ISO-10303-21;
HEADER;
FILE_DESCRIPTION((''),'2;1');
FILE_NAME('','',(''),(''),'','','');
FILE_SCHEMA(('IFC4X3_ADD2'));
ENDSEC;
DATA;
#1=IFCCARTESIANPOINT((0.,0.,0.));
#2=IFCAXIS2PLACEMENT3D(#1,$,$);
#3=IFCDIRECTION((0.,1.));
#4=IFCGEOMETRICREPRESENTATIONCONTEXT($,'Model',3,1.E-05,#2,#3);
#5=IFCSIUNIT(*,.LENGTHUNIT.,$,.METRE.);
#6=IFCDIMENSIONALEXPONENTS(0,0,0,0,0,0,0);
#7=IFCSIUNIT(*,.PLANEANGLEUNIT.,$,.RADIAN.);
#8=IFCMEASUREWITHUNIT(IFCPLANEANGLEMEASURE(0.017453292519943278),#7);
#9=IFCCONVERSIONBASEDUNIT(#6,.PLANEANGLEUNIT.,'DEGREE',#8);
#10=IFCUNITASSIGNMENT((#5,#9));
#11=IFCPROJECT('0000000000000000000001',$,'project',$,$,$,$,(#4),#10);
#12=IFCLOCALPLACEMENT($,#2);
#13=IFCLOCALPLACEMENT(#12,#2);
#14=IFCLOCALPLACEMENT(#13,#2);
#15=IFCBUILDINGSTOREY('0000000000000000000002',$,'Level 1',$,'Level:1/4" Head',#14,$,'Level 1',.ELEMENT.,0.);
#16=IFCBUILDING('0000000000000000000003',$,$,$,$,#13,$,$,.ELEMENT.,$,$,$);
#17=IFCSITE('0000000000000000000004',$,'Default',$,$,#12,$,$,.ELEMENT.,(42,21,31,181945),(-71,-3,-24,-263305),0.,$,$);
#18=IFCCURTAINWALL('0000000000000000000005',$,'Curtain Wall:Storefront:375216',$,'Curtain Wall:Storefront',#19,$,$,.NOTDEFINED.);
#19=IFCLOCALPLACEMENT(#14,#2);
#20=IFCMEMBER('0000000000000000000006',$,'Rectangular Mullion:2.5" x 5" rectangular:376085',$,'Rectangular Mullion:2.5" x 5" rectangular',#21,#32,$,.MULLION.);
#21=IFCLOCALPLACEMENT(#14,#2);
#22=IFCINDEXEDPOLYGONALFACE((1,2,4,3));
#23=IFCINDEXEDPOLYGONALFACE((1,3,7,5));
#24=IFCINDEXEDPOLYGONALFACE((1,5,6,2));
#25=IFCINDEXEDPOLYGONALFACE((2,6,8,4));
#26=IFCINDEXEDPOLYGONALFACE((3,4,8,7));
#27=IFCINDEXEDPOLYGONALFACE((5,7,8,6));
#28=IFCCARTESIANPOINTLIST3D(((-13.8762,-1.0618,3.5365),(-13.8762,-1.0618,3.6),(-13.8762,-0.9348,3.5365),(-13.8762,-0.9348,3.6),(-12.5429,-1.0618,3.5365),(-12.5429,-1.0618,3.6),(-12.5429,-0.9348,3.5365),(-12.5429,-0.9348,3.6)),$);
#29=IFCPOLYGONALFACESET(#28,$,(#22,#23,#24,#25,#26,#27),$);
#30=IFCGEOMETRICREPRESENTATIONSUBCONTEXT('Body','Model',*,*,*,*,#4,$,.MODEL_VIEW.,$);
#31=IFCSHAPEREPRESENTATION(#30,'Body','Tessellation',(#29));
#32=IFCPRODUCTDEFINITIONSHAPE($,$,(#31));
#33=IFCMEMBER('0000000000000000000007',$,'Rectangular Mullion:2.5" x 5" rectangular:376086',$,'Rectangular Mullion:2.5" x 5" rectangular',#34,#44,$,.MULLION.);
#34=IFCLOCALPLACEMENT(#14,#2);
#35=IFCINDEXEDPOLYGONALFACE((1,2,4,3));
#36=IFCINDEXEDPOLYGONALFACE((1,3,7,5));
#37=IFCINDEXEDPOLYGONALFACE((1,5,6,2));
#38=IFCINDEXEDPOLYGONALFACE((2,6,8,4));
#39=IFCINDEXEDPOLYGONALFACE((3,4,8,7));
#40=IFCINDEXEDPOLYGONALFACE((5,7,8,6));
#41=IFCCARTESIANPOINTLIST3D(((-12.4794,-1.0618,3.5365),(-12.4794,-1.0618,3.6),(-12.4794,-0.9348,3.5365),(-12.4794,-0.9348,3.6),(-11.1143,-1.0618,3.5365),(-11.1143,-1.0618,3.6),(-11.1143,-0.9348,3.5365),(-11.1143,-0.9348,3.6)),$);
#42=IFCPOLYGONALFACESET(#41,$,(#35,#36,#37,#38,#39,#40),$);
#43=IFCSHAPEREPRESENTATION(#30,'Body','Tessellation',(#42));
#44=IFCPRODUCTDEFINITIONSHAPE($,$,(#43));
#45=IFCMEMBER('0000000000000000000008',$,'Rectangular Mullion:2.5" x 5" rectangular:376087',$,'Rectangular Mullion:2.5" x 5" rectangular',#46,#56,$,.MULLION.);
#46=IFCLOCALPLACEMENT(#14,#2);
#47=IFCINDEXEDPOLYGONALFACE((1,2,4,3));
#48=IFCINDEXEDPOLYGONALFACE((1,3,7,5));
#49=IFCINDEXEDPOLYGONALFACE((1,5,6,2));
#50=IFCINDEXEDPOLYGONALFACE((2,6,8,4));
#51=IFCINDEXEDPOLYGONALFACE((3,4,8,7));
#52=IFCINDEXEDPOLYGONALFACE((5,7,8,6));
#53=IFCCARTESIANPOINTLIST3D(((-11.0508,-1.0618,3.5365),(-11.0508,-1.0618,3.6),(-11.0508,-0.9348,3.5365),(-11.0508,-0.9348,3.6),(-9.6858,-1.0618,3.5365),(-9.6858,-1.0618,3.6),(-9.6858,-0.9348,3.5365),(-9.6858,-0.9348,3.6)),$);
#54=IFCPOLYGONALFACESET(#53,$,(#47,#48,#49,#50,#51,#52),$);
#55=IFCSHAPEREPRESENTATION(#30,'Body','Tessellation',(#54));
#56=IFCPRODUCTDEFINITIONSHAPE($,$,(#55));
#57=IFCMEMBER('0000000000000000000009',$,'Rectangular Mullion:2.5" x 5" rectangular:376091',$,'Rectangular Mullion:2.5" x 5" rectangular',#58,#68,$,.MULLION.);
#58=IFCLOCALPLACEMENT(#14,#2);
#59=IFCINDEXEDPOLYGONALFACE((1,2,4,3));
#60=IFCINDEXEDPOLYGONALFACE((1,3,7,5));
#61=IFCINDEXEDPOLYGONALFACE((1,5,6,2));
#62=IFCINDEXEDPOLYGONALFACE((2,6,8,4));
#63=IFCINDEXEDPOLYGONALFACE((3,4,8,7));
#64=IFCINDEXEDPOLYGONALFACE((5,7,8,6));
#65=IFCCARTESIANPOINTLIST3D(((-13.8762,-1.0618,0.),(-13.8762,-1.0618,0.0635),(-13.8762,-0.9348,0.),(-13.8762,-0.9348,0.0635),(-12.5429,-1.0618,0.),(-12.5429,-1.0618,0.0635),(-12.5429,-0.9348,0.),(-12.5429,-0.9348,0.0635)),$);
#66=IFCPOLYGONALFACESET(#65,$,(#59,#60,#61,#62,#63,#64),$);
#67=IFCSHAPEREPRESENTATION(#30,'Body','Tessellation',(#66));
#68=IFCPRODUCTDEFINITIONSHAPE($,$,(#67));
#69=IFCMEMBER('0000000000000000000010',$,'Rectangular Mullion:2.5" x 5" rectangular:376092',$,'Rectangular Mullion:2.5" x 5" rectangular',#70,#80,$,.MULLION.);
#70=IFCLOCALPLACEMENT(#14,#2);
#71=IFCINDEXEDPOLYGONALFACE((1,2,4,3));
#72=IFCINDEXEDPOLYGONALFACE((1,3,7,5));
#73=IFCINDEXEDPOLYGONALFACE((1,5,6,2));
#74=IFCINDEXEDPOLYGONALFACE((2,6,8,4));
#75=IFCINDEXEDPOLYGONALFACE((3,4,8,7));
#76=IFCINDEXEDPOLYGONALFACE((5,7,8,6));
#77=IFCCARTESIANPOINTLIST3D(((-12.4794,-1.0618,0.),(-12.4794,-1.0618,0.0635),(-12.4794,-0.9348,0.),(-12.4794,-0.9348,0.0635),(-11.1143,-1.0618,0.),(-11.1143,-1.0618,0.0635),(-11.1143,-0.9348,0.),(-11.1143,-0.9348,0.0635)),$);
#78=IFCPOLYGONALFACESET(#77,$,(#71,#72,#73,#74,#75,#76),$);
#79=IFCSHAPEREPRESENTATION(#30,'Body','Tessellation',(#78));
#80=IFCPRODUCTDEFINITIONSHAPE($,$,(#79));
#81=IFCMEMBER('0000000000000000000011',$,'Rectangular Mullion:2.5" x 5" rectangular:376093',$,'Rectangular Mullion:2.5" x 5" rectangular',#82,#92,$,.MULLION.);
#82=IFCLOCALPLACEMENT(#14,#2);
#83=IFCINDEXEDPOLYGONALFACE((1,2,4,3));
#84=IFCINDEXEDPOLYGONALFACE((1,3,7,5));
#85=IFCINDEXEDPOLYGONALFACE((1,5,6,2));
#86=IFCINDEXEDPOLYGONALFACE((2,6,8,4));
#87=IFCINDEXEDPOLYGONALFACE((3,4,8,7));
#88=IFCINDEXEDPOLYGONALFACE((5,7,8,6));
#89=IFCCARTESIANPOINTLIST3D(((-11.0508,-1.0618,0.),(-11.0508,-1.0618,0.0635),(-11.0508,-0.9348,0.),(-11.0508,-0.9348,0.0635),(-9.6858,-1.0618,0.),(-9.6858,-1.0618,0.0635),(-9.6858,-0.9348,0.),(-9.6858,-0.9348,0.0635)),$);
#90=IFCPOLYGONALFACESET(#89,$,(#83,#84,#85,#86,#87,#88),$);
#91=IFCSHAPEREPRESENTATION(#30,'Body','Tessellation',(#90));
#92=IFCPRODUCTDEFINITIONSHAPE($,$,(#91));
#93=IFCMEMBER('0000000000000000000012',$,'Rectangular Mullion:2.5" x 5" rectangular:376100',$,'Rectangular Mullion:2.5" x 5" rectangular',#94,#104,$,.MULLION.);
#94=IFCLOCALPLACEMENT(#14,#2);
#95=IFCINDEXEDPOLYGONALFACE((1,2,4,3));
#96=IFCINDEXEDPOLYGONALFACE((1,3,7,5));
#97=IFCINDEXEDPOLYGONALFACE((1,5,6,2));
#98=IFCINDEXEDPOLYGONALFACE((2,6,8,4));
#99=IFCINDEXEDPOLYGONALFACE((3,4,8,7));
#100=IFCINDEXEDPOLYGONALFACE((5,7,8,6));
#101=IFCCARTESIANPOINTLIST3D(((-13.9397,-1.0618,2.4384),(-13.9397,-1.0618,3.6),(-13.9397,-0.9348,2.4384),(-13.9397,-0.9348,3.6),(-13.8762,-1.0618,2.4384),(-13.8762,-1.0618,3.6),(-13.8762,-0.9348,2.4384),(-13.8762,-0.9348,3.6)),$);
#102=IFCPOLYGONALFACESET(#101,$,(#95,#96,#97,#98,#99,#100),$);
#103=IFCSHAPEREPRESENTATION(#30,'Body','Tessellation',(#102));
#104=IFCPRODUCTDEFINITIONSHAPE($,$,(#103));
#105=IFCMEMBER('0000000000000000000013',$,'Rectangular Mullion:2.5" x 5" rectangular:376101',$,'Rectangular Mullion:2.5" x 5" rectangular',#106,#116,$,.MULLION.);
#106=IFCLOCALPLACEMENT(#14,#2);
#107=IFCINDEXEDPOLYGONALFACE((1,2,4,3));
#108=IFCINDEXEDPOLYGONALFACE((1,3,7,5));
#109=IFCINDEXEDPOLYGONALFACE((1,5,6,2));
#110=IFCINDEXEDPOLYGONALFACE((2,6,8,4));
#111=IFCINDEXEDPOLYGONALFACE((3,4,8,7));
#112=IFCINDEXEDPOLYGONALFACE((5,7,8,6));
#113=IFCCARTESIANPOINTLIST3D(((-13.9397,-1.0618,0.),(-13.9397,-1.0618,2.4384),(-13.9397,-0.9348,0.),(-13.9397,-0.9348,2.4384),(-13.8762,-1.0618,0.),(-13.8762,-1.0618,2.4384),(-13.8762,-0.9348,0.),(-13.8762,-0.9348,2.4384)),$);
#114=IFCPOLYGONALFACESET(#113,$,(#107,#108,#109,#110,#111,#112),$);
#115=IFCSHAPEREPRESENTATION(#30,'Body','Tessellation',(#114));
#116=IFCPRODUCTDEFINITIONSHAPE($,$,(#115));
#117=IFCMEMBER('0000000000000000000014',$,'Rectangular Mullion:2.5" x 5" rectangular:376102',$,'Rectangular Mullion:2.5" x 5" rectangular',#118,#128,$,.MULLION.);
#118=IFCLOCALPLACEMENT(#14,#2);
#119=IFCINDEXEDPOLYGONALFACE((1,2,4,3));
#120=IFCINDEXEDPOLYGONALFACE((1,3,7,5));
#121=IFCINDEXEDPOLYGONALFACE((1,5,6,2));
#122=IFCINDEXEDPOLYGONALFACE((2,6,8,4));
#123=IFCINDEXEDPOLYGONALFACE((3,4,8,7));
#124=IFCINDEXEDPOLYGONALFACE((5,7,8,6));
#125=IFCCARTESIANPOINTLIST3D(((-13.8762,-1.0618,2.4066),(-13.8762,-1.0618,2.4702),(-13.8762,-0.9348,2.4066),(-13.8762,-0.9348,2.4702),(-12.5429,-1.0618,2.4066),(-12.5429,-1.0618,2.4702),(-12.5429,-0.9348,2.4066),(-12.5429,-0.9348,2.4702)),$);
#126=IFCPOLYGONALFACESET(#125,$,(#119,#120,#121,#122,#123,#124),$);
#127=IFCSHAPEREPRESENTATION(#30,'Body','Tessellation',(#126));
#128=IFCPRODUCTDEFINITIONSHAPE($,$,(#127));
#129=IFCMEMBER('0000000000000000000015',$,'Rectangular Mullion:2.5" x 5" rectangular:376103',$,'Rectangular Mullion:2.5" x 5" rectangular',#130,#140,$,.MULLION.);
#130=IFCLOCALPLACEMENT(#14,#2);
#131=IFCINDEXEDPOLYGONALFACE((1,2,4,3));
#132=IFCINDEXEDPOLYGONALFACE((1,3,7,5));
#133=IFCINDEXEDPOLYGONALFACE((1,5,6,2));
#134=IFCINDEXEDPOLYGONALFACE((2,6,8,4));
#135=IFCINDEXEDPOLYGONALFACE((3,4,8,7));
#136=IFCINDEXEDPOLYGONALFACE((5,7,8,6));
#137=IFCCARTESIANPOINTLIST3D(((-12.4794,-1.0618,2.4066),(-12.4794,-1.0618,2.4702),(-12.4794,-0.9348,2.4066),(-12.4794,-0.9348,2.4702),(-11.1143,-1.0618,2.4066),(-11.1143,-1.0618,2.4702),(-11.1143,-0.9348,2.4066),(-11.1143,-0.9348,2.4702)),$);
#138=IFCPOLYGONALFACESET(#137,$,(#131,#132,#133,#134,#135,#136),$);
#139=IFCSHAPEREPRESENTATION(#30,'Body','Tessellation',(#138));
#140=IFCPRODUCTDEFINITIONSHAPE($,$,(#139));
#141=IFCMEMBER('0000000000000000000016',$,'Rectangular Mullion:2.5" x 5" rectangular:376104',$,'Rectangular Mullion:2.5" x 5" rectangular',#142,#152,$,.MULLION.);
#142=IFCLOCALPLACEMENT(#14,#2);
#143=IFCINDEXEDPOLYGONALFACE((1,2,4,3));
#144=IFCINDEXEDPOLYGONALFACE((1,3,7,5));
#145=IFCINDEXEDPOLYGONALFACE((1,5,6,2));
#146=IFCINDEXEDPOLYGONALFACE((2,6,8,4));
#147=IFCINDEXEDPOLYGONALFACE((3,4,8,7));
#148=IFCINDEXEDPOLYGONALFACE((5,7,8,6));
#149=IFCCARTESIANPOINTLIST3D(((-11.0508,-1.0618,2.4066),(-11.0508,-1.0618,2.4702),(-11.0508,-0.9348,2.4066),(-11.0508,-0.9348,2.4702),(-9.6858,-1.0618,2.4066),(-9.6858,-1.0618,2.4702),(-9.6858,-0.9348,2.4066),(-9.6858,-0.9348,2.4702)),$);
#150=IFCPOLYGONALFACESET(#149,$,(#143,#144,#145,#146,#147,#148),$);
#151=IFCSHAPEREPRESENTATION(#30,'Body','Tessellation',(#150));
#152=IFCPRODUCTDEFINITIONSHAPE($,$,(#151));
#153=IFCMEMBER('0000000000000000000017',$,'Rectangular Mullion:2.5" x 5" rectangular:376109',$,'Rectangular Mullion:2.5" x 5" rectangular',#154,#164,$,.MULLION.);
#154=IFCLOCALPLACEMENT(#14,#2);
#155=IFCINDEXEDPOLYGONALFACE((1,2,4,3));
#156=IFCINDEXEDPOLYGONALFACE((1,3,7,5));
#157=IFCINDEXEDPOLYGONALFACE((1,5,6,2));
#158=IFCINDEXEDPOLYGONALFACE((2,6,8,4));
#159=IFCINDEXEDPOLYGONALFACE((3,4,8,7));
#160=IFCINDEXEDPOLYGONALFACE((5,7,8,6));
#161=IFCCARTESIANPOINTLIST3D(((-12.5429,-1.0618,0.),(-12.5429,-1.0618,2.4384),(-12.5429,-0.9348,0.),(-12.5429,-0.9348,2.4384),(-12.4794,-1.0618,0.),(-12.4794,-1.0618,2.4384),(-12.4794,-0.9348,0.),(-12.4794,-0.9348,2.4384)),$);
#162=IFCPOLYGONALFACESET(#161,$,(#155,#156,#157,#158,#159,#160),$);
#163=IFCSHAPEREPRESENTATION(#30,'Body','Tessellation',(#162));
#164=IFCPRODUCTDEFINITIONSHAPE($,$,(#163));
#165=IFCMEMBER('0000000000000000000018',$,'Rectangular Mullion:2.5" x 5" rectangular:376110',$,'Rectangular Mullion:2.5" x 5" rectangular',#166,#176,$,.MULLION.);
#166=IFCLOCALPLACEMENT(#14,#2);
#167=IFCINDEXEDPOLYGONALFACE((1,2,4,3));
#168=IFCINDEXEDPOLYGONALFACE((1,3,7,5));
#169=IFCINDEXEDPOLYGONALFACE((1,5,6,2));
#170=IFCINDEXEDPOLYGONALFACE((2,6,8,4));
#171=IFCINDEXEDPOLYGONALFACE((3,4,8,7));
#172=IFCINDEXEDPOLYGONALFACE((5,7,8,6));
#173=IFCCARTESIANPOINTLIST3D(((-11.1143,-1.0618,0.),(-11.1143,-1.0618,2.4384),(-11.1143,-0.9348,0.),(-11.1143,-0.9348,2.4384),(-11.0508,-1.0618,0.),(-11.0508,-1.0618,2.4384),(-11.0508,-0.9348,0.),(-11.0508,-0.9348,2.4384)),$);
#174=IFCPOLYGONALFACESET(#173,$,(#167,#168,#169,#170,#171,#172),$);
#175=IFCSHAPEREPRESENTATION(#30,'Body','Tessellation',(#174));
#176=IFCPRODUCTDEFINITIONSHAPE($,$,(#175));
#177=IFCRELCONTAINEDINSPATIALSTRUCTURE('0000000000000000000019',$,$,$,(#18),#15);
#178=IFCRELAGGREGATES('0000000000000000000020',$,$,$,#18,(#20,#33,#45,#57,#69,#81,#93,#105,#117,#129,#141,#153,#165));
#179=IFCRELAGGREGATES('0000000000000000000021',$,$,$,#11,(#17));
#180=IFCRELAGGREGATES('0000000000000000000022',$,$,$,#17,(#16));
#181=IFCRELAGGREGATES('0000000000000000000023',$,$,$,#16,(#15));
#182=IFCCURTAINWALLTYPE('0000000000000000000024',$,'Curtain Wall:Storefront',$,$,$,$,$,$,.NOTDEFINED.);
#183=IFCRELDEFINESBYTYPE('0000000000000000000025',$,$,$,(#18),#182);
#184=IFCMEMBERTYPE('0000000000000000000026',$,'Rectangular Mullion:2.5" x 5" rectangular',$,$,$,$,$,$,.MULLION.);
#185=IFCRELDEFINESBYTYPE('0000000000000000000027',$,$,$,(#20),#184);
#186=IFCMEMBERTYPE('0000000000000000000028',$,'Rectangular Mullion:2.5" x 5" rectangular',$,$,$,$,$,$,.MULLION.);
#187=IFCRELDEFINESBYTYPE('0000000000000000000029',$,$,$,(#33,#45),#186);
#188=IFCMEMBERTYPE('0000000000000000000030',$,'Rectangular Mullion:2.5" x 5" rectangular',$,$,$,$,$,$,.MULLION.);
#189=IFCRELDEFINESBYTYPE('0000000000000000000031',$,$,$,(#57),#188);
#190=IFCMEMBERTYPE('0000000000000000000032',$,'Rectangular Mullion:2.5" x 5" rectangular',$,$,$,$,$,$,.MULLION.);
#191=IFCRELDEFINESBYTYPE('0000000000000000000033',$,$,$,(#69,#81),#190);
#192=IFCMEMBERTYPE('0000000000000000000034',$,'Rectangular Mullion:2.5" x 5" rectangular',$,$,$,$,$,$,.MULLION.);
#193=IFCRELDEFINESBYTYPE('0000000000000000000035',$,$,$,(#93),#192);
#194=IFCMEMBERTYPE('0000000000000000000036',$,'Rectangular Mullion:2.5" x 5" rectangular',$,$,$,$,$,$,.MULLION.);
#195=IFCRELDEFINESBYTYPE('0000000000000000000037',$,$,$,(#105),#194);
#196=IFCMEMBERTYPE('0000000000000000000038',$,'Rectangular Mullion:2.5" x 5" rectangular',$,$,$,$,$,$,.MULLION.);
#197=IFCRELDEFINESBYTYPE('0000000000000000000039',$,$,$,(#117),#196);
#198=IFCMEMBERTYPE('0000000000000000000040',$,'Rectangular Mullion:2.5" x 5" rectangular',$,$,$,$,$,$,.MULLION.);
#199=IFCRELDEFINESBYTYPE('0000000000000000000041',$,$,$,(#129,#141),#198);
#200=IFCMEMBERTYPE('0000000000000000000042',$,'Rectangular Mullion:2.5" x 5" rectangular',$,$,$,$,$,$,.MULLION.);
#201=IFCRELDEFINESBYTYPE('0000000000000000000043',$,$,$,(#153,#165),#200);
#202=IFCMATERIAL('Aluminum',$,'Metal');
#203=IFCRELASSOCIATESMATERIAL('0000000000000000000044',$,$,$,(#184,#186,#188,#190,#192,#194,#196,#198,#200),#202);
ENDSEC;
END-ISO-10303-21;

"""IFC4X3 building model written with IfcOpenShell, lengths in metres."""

from ifc_helpers import new_model, entity, si_unit, converted_unit, direction, frame, frame_2d, origin, origin_2d_with_axis, place, context, subcontext, project, spatial, rectangle, extrude, source, transform, mapped, material, material_profile, profile_set, type_object, type_shapes, element, aggregate, save


model = new_model("IFC4X3")

# Units and contexts
model_context = context("Model", 3, precision=1e-05, world=origin(), true_north=direction((0.0, 1.0)))
body_context = subcontext(model_context, "Body", "Model", "MODEL_VIEW")
ifc_project = project(units=[si_unit("LENGTHUNIT", "METRE"), converted_unit("PLANEANGLEUNIT", "DEGREE", entity("IfcPlaneAngleMeasure", 0.017453292519943278), si_unit("PLANEANGLEUNIT", "RADIAN"), dimensions=[0, 0, 0, 0, 0, 0, 0])], contexts=[model_context])

# Site, building, storey
site_placement = place(None, origin())
site = spatial("IfcSite", under=ifc_project, at=site_placement, Name="Default", CompositionType="ELEMENT", RefLatitude=(42, 21, 31, 181945), RefLongitude=(-71, -3, -24, -263305), RefElevation=0.0)
building_placement = place(site_placement, origin())
building = spatial("IfcBuilding", under=site, at=building_placement, CompositionType="ELEMENT")
storey_placement = place(building_placement, origin())
storey = spatial("IfcBuildingStorey", under=building, at=storey_placement, Name="Level 1", ObjectType="Level:1/4\" Head", LongName="Level 1", CompositionType="ELEMENT", Elevation=0.0)

# Curtain wall, members
curtain_wall_type = type_object("IfcCurtainWallType", Name="Curtain Wall:Storefront", PredefinedType="NOTDEFINED")
curtain_wall_placement = place(storey_placement, origin())
curtain_wall = element("IfcCurtainWall", 1, at=curtain_wall_placement, inside=storey, type_object=curtain_wall_type, Name="Curtain Wall:Storefront:375216", ObjectType="Curtain Wall:Storefront", PredefinedType="NOTDEFINED")
ifc_material_1 = material(Name="Aluminum", Category="Metal")
ifc_material_profile = material_profile(ifc_material_1, rectangle(XDim=0.0635, YDim=0.127, at=frame_2d((0.0, 0.0), x_axis=(1.0, 0.0))), Name="2.5\" x 5\" rectangular")
ifc_profile_set = profile_set([ifc_material_profile], Name="2.5\" x 5\" rectangular")
member_type_1 = type_object("IfcMemberType", Name="Rectangular Mullion:2.5\" x 5\" rectangular", PredefinedType="MULLION", material=ifc_profile_set)
shared_shape_1 = source(origin(), body_context, "Body", "SweptSolid", [
    extrude(rectangle(XDim=0.0635, YDim=0.127, at=frame_2d((0.0, 0.0), x_axis=(1.0, 0.0))), frame((-0.0318, 0.0, -1.3333), z_axis=(0.0, 0.0, 1.0), x_axis=(-1.0, 0.0, 0.0)), (0.0, 0.0, 1.0), 1.3333),
])
type_shapes(member_type_1, [shared_shape_1])
member_1_placement = place(curtain_wall_placement, frame((-12.5429, -0.9983, 3.6), z_axis=(1.0, 0.0, 0.0), x_axis=(0.0, 0.0, 1.0)))
member_1 = element("IfcMember", 2, at=member_1_placement, type_object=member_type_1, Name="Rectangular Mullion:2.5\" x 5\" rectangular:376085", ObjectType="Rectangular Mullion:2.5\" x 5\" rectangular", PredefinedType="MULLION", context=body_context, shape_type="MappedRepresentation", body=[
    mapped(shared_shape_1, transform((0.0, 0.0, 0.0), scale=1.0)),
])
member_type_2 = type_object("IfcMemberType", Name="Rectangular Mullion:2.5\" x 5\" rectangular", PredefinedType="MULLION", material=ifc_profile_set)
shared_shape_2 = source(origin(), body_context, "Body", "SweptSolid", [
    extrude(rectangle(XDim=0.0635, YDim=0.127, at=frame_2d((0.0, 0.0), x_axis=(1.0, 0.0))), frame((-0.0318, 0.0, -1.3651), z_axis=(0.0, 0.0, 1.0), x_axis=(-1.0, 0.0, 0.0)), (0.0, 0.0, 1.0), 1.3651),
])
type_shapes(member_type_2, [shared_shape_2])
member_2_placement = place(curtain_wall_placement, frame((-11.1143, -0.9983, 3.6), z_axis=(1.0, 0.0, 0.0), x_axis=(0.0, 0.0, 1.0)))
member_2 = element("IfcMember", 3, at=member_2_placement, type_object=member_type_2, Name="Rectangular Mullion:2.5\" x 5\" rectangular:376086", ObjectType="Rectangular Mullion:2.5\" x 5\" rectangular", PredefinedType="MULLION", context=body_context, shape_type="MappedRepresentation", body=[
    mapped(shared_shape_2, transform((0.0, 0.0, 0.0), scale=1.0)),
])
member_3_placement = place(curtain_wall_placement, frame((-9.6858, -0.9983, 3.6), z_axis=(1.0, 0.0, 0.0), x_axis=(0.0, 0.0, 1.0)))
member_3 = element("IfcMember", 4, at=member_3_placement, type_object=member_type_2, Name="Rectangular Mullion:2.5\" x 5\" rectangular:376087", ObjectType="Rectangular Mullion:2.5\" x 5\" rectangular", PredefinedType="MULLION", context=body_context, shape_type="MappedRepresentation", body=[
    mapped(shared_shape_2, transform((0.0, 0.0, 0.0), scale=1.0)),
])
member_type_3 = type_object("IfcMemberType", Name="Rectangular Mullion:2.5\" x 5\" rectangular", PredefinedType="MULLION", material=ifc_profile_set)
shared_shape_3 = source(origin(), body_context, "Body", "SweptSolid", [
    extrude(rectangle(XDim=0.0635, YDim=0.127, at=frame_2d((0.0, 0.0), x_axis=(1.0, 0.0))), frame((-0.0318, 0.0, -1.3333), z_axis=(0.0, 0.0, 1.0), x_axis=(-1.0, 0.0, 0.0)), (0.0, 0.0, 1.0), 1.3333),
])
type_shapes(member_type_3, [shared_shape_3])
member_4_placement = place(curtain_wall_placement, frame((-13.8762, -0.9983, 0.0), z_axis=(-1.0, 0.0, 0.0), x_axis=(0.0, 0.0, -1.0)))
member_4 = element("IfcMember", 5, at=member_4_placement, type_object=member_type_3, Name="Rectangular Mullion:2.5\" x 5\" rectangular:376091", ObjectType="Rectangular Mullion:2.5\" x 5\" rectangular", PredefinedType="MULLION", context=body_context, shape_type="MappedRepresentation", body=[
    mapped(shared_shape_3, transform((0.0, 0.0, 0.0), scale=1.0)),
])
member_type_4 = type_object("IfcMemberType", Name="Rectangular Mullion:2.5\" x 5\" rectangular", PredefinedType="MULLION", material=ifc_profile_set)
shared_shape_4 = source(origin(), body_context, "Body", "SweptSolid", [
    extrude(rectangle(XDim=0.0635, YDim=0.127, at=frame_2d((0.0, 0.0), x_axis=(1.0, 0.0))), frame((-0.0318, 0.0, -1.3651), z_axis=(0.0, 0.0, 1.0), x_axis=(-1.0, 0.0, 0.0)), (0.0, 0.0, 1.0), 1.3651),
])
type_shapes(member_type_4, [shared_shape_4])
member_5_placement = place(curtain_wall_placement, frame((-12.4794, -0.9983, 0.0), z_axis=(-1.0, 0.0, 0.0), x_axis=(0.0, 0.0, -1.0)))
member_5 = element("IfcMember", 6, at=member_5_placement, type_object=member_type_4, Name="Rectangular Mullion:2.5\" x 5\" rectangular:376092", ObjectType="Rectangular Mullion:2.5\" x 5\" rectangular", PredefinedType="MULLION", context=body_context, shape_type="MappedRepresentation", body=[
    mapped(shared_shape_4, transform((0.0, 0.0, 0.0), scale=1.0)),
])
member_6_placement = place(curtain_wall_placement, frame((-11.0508, -0.9983, 0.0), z_axis=(-1.0, 0.0, 0.0), x_axis=(0.0, 0.0, -1.0)))
member_6 = element("IfcMember", 7, at=member_6_placement, type_object=member_type_4, Name="Rectangular Mullion:2.5\" x 5\" rectangular:376093", ObjectType="Rectangular Mullion:2.5\" x 5\" rectangular", PredefinedType="MULLION", context=body_context, shape_type="MappedRepresentation", body=[
    mapped(shared_shape_4, transform((0.0, 0.0, 0.0), scale=1.0)),
])
member_type_5 = type_object("IfcMemberType", Name="Rectangular Mullion:2.5\" x 5\" rectangular", PredefinedType="MULLION", material=ifc_profile_set)
shared_shape_5 = source(origin(), body_context, "Body", "SweptSolid", [
    extrude(rectangle(XDim=0.0635, YDim=0.127, at=frame_2d((0.0, 0.0), x_axis=(1.0, 0.0))), frame((-0.0318, 0.0, -1.1616), z_axis=(0.0, 0.0, 1.0), x_axis=(-1.0, 0.0, 0.0)), (0.0, 0.0, 1.0), 1.1616),
])
type_shapes(member_type_5, [shared_shape_5])
member_7_placement = place(curtain_wall_placement, frame((-13.9397, -0.9983, 3.6), z_axis=(0.0, 0.0, 1.0), x_axis=(-1.0, 0.0, 0.0)))
member_7 = element("IfcMember", 8, at=member_7_placement, type_object=member_type_5, Name="Rectangular Mullion:2.5\" x 5\" rectangular:376100", ObjectType="Rectangular Mullion:2.5\" x 5\" rectangular", PredefinedType="MULLION", context=body_context, shape_type="MappedRepresentation", body=[
    mapped(shared_shape_5, transform((0.0, 0.0, 0.0), scale=1.0)),
])
member_type_6 = type_object("IfcMemberType", Name="Rectangular Mullion:2.5\" x 5\" rectangular", PredefinedType="MULLION", material=ifc_profile_set)
shared_shape_6 = source(origin(), body_context, "Body", "SweptSolid", [
    extrude(rectangle(XDim=0.0635, YDim=0.127, at=frame_2d((0.0, 0.0), x_axis=(1.0, 0.0))), frame((-0.0318, 0.0, -2.4384), z_axis=(0.0, 0.0, 1.0), x_axis=(-1.0, 0.0, 0.0)), (0.0, 0.0, 1.0), 2.4384),
])
type_shapes(member_type_6, [shared_shape_6])
member_8_placement = place(curtain_wall_placement, frame((-13.9397, -0.9983, 2.4384), z_axis=(0.0, 0.0, 1.0), x_axis=(-1.0, 0.0, 0.0)))
member_8 = element("IfcMember", 9, at=member_8_placement, type_object=member_type_6, Name="Rectangular Mullion:2.5\" x 5\" rectangular:376101", ObjectType="Rectangular Mullion:2.5\" x 5\" rectangular", PredefinedType="MULLION", context=body_context, shape_type="MappedRepresentation", body=[
    mapped(shared_shape_6, transform((0.0, 0.0, 0.0), scale=1.0)),
])
member_type_7 = type_object("IfcMemberType", Name="Rectangular Mullion:2.5\" x 5\" rectangular", PredefinedType="MULLION", material=ifc_profile_set)
shared_shape_7 = source(origin(), body_context, "Body", "SweptSolid", [
    extrude(rectangle(XDim=0.0635, YDim=0.127, at=origin_2d_with_axis()), frame((0.0, 0.0, -1.3333), z_axis=(0.0, 0.0, 1.0), x_axis=(-1.0, 0.0, 0.0)), (0.0, 0.0, 1.0), 1.3333),
])
type_shapes(member_type_7, [shared_shape_7])
member_9_placement = place(curtain_wall_placement, frame((-12.5429, -0.9983, 2.4384), z_axis=(1.0, 0.0, 0.0), x_axis=(0.0, 0.0, 1.0)))
member_9 = element("IfcMember", 10, at=member_9_placement, type_object=member_type_7, Name="Rectangular Mullion:2.5\" x 5\" rectangular:376102", ObjectType="Rectangular Mullion:2.5\" x 5\" rectangular", PredefinedType="MULLION", context=body_context, shape_type="MappedRepresentation", body=[
    mapped(shared_shape_7, transform((0.0, 0.0, 0.0), scale=1.0)),
])
member_type_8 = type_object("IfcMemberType", Name="Rectangular Mullion:2.5\" x 5\" rectangular", PredefinedType="MULLION", material=ifc_profile_set)
shared_shape_8 = source(origin(), body_context, "Body", "SweptSolid", [
    extrude(rectangle(XDim=0.0635, YDim=0.127, at=origin_2d_with_axis()), frame((0.0, 0.0, -1.3651), z_axis=(0.0, 0.0, 1.0), x_axis=(-1.0, 0.0, 0.0)), (0.0, 0.0, 1.0), 1.3651),
])
type_shapes(member_type_8, [shared_shape_8])
member_10_placement = place(curtain_wall_placement, frame((-11.1143, -0.9983, 2.4384), z_axis=(1.0, 0.0, 0.0), x_axis=(0.0, 0.0, 1.0)))
member_10 = element("IfcMember", 11, at=member_10_placement, type_object=member_type_8, Name="Rectangular Mullion:2.5\" x 5\" rectangular:376103", ObjectType="Rectangular Mullion:2.5\" x 5\" rectangular", PredefinedType="MULLION", context=body_context, shape_type="MappedRepresentation", body=[
    mapped(shared_shape_8, transform((0.0, 0.0, 0.0), scale=1.0)),
])
member_11_placement = place(curtain_wall_placement, frame((-9.6858, -0.9983, 2.4384), z_axis=(1.0, 0.0, 0.0), x_axis=(0.0, 0.0, 1.0)))
member_11 = element("IfcMember", 12, at=member_11_placement, type_object=member_type_8, Name="Rectangular Mullion:2.5\" x 5\" rectangular:376104", ObjectType="Rectangular Mullion:2.5\" x 5\" rectangular", PredefinedType="MULLION", context=body_context, shape_type="MappedRepresentation", body=[
    mapped(shared_shape_8, transform((0.0, 0.0, 0.0), scale=1.0)),
])
member_type_9 = type_object("IfcMemberType", Name="Rectangular Mullion:2.5\" x 5\" rectangular", PredefinedType="MULLION", material=ifc_profile_set)
shared_shape_9 = source(origin(), body_context, "Body", "SweptSolid", [
    extrude(rectangle(XDim=0.0635, YDim=0.127, at=origin_2d_with_axis()), frame((0.0, 0.0, -2.4384), z_axis=(0.0, 0.0, 1.0), x_axis=(-1.0, 0.0, 0.0)), (0.0, 0.0, 1.0), 2.4384),
])
type_shapes(member_type_9, [shared_shape_9])
member_12_placement = place(curtain_wall_placement, frame((-12.5112, -0.9983, 0.0), z_axis=(0.0, 0.0, -1.0), x_axis=(1.0, 0.0, 0.0)))
member_12 = element("IfcMember", 13, at=member_12_placement, type_object=member_type_9, Name="Rectangular Mullion:2.5\" x 5\" rectangular:376109", ObjectType="Rectangular Mullion:2.5\" x 5\" rectangular", PredefinedType="MULLION", context=body_context, shape_type="MappedRepresentation", body=[
    mapped(shared_shape_9, transform((0.0, 0.0, 0.0), scale=1.0)),
])
member_13_placement = place(curtain_wall_placement, frame((-11.0826, -0.9983, 0.0), z_axis=(0.0, 0.0, -1.0), x_axis=(1.0, 0.0, 0.0)))
member_13 = element("IfcMember", 14, at=member_13_placement, type_object=member_type_9, Name="Rectangular Mullion:2.5\" x 5\" rectangular:376110", ObjectType="Rectangular Mullion:2.5\" x 5\" rectangular", PredefinedType="MULLION", context=body_context, shape_type="MappedRepresentation", body=[
    mapped(shared_shape_9, transform((0.0, 0.0, 0.0), scale=1.0)),
])
aggregate(curtain_wall, [member_1, member_2, member_3, member_4, member_5, member_6, member_7, member_8, member_9, member_10, member_11, member_12, member_13])

save(model, "model.ifc")
